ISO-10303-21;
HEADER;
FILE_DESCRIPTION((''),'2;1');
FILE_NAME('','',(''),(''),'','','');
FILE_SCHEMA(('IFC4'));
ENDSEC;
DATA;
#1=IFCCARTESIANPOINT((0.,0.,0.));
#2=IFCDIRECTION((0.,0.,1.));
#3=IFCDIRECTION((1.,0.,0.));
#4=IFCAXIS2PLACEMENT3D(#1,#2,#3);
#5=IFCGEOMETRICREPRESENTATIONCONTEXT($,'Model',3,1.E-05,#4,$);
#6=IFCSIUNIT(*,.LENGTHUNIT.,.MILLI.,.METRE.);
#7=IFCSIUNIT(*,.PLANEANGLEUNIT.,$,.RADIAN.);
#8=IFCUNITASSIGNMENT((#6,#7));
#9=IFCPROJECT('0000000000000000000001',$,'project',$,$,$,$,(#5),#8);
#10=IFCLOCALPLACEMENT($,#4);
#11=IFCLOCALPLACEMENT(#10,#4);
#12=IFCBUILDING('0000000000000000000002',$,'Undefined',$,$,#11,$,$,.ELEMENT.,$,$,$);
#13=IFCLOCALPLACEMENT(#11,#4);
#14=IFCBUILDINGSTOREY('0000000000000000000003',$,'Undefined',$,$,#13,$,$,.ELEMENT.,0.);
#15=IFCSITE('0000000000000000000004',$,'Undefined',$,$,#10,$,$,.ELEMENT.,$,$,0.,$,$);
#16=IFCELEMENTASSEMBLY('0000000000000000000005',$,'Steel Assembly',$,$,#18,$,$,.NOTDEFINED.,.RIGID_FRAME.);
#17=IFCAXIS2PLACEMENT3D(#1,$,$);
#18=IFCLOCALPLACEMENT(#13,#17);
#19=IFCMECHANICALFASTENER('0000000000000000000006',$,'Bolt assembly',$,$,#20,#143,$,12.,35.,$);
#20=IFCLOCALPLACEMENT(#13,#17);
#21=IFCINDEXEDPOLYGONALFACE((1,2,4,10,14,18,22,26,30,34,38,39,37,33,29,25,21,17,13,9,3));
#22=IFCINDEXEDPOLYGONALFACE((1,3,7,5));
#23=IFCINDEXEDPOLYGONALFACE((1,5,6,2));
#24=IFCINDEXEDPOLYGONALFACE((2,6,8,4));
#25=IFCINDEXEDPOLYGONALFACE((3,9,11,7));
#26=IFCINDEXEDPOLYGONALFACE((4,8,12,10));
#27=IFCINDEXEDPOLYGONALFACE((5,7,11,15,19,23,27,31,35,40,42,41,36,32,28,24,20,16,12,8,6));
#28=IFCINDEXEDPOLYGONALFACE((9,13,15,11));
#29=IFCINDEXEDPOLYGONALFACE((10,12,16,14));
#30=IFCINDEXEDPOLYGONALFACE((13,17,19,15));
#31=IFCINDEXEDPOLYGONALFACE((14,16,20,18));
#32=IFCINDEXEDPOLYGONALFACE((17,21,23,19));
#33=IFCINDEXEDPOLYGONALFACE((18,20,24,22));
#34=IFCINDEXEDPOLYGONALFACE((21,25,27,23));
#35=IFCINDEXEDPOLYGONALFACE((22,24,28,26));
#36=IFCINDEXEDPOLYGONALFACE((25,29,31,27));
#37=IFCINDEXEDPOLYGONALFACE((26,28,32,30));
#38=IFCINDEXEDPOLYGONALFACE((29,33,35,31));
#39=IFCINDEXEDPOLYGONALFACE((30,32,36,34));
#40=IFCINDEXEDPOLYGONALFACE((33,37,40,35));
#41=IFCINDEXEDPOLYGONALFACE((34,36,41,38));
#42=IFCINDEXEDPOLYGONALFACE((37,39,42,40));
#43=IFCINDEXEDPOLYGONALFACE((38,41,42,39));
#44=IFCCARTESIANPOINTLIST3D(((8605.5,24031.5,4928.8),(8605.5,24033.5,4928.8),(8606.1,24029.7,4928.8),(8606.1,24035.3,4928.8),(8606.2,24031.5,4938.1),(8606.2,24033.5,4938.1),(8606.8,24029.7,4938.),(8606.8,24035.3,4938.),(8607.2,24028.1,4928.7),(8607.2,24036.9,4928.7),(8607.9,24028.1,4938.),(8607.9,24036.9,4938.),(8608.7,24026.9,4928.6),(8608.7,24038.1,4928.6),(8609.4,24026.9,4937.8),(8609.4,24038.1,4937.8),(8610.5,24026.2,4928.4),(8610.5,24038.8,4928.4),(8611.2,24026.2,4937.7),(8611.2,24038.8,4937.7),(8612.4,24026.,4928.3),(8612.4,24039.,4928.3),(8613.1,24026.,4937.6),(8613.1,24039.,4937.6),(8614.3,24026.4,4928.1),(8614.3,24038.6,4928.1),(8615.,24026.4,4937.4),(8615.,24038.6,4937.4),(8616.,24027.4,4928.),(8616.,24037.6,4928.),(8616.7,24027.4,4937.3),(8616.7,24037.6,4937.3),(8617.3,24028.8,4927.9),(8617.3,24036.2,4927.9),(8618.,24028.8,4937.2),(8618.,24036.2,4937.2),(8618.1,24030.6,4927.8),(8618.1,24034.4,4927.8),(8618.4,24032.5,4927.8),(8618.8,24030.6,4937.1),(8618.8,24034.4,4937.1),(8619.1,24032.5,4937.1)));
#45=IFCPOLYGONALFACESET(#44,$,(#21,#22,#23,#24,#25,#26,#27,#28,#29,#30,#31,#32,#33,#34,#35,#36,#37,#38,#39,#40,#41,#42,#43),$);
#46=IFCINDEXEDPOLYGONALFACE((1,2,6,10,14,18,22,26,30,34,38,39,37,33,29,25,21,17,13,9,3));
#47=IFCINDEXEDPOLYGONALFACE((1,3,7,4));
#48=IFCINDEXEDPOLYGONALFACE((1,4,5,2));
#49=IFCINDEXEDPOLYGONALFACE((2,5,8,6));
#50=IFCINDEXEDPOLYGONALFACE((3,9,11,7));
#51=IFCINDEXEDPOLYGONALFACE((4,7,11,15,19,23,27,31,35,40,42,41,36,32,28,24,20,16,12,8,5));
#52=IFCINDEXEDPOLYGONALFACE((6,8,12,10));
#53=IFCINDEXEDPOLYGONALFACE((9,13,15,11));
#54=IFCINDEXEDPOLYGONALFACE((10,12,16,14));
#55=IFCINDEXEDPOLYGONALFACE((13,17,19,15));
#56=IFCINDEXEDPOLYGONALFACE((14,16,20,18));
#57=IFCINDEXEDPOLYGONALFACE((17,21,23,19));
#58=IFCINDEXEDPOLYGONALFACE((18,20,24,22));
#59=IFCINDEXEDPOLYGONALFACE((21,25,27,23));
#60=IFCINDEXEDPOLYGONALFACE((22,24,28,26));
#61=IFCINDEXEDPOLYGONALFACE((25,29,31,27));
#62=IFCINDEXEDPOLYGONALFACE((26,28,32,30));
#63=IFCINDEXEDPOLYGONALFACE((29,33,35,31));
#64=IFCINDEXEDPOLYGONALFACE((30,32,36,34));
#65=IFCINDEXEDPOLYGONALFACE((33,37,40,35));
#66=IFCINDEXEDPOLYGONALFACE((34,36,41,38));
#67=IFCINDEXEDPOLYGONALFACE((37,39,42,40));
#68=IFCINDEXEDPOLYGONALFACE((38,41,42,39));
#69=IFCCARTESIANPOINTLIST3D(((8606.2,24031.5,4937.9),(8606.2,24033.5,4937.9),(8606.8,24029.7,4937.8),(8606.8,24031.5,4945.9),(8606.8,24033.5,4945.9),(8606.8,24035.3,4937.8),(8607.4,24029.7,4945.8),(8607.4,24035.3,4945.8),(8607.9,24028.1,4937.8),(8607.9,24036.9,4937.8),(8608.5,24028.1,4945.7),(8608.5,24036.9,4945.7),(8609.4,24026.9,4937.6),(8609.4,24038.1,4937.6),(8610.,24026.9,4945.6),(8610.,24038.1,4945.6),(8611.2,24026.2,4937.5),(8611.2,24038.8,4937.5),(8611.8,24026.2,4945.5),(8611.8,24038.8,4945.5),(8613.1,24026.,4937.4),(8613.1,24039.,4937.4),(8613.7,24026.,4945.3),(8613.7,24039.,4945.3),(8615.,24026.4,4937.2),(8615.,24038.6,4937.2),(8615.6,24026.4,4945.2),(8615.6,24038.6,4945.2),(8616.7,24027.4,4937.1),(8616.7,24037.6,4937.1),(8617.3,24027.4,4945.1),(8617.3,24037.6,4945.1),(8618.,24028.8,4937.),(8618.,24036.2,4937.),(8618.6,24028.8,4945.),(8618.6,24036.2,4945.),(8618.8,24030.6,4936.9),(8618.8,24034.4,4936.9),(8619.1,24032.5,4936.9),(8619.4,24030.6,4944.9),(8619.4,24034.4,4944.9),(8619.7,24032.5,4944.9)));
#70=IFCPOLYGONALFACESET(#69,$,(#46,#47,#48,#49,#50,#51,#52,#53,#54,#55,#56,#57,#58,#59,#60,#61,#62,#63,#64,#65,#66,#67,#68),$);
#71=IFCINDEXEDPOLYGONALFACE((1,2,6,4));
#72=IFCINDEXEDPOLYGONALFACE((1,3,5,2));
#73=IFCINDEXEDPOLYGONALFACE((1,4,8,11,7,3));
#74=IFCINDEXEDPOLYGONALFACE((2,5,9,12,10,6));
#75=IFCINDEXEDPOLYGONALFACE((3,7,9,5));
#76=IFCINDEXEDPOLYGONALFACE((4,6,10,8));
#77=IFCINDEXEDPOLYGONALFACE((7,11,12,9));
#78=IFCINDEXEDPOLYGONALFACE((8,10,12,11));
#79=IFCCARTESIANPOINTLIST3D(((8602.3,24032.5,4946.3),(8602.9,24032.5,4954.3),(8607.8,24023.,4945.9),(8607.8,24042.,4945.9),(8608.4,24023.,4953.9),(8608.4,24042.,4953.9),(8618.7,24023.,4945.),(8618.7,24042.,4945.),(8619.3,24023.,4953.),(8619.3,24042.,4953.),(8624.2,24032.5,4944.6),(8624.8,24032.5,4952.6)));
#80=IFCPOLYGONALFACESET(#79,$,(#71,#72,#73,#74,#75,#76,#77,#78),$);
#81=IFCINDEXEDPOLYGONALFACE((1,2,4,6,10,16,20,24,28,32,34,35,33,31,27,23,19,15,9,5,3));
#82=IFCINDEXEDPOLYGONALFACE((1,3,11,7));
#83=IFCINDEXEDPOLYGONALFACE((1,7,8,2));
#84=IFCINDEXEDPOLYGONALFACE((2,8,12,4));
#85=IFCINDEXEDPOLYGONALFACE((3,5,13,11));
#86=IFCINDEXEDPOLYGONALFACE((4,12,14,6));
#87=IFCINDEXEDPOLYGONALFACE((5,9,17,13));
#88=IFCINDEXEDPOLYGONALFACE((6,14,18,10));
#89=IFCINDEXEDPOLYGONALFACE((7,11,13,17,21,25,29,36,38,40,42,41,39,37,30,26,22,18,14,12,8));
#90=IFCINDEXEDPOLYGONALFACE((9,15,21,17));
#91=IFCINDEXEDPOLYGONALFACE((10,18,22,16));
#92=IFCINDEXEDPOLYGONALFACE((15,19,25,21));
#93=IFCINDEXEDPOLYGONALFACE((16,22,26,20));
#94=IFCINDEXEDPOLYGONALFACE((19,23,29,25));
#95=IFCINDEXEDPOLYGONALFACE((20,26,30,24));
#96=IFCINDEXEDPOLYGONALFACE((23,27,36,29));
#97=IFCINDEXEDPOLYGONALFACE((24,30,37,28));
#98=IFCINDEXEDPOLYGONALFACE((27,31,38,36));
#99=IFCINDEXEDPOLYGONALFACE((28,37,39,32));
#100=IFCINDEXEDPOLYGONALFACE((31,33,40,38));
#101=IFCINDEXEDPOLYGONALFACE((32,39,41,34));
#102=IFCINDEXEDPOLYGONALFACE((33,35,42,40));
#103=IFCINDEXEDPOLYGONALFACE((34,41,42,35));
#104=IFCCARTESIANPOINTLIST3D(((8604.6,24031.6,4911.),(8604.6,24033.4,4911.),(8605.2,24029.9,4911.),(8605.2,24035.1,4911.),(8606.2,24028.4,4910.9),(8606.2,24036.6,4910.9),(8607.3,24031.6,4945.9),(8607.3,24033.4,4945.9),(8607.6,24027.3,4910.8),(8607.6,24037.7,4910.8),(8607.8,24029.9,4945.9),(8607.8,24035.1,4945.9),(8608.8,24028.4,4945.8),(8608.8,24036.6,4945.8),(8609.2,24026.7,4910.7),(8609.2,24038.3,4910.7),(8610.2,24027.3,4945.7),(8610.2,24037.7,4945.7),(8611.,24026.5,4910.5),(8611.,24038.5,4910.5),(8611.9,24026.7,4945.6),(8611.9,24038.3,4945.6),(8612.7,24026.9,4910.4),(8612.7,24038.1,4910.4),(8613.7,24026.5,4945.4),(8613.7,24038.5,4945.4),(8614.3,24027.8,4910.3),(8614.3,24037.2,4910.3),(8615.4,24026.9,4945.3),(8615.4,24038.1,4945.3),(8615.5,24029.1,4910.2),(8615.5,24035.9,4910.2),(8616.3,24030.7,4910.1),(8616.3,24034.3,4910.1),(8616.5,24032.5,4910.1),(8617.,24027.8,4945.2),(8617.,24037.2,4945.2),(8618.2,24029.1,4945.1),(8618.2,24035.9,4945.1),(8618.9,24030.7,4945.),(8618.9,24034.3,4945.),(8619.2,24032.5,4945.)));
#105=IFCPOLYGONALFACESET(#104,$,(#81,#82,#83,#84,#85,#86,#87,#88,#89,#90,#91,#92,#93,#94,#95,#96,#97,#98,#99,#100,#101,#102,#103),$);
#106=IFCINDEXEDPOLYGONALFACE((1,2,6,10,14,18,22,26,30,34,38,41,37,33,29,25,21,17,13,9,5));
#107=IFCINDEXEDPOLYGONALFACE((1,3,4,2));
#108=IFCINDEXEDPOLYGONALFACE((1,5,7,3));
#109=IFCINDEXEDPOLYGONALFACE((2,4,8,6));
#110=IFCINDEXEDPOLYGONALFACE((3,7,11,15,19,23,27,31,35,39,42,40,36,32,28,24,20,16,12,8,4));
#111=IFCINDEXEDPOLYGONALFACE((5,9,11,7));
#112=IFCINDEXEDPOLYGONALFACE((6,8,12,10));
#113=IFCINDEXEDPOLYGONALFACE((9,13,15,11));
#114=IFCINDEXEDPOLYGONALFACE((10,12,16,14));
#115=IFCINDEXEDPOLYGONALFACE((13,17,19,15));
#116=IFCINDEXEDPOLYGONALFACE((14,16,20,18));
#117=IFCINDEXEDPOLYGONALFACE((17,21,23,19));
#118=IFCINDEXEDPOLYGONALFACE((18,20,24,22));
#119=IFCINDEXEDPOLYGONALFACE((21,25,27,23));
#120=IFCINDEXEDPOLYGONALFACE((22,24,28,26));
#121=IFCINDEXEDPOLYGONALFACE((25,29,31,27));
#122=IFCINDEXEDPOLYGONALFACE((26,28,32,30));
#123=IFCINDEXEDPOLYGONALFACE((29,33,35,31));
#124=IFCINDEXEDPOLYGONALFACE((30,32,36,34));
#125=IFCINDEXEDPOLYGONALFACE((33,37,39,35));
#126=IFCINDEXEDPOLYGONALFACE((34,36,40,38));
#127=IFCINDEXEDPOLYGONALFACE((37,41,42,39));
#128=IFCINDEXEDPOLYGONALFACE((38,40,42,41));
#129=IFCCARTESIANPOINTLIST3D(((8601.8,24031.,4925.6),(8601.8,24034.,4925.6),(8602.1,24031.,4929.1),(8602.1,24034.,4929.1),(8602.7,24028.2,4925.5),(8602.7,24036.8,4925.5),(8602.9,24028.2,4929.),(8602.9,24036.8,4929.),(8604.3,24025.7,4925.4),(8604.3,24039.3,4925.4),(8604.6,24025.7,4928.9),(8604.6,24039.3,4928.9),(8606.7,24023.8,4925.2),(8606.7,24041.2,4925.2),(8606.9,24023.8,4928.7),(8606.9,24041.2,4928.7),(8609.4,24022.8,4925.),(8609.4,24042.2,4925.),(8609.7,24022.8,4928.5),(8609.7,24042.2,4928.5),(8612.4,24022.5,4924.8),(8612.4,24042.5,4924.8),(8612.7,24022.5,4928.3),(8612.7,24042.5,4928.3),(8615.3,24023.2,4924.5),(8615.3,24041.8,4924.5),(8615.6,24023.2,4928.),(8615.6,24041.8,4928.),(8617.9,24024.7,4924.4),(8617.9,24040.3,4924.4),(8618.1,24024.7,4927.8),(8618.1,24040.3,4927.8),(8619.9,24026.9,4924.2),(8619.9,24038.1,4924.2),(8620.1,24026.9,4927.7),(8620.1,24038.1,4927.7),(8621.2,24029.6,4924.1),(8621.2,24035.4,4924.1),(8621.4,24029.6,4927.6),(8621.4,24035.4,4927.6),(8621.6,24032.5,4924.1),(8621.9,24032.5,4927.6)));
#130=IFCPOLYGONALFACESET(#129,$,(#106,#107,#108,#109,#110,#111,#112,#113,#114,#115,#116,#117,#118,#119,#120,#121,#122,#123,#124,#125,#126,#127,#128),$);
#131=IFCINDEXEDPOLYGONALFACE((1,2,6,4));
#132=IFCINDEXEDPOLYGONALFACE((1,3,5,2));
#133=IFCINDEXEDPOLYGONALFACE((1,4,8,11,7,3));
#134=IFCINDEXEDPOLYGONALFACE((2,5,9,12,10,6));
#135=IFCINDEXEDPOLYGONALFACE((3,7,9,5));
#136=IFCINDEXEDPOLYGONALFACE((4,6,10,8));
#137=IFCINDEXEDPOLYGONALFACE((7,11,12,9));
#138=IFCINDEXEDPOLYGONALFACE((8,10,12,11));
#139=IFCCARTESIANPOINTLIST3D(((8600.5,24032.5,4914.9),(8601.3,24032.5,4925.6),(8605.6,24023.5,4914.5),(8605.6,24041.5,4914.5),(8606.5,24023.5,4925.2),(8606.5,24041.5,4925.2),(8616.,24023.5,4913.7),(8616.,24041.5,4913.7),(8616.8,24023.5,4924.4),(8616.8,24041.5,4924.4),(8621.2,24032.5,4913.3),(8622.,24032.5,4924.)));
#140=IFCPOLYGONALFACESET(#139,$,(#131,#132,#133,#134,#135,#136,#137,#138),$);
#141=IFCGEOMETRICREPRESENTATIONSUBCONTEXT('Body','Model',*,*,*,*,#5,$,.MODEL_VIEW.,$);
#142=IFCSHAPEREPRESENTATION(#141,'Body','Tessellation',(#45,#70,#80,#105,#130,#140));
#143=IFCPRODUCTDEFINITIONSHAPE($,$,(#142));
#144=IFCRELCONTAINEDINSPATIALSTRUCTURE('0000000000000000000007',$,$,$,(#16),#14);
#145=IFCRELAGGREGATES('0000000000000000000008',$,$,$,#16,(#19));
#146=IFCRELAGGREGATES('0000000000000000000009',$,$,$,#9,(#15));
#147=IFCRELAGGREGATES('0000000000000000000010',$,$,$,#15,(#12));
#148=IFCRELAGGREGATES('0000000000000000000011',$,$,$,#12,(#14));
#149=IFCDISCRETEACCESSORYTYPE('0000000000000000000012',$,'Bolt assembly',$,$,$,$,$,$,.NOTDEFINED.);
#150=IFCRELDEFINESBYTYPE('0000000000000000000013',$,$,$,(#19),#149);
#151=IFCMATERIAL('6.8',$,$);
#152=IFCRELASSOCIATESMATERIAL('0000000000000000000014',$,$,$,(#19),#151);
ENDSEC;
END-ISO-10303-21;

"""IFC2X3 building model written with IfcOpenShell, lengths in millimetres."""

from ifc_helpers import new_model, si_unit, frame, origin_with_axes, origin_2d_with_axis, place, context, subcontext, project, spatial, polyline, circle, outline, extrude, source, transform, mapped, material, type_object, element, aggregate, save


model = new_model("IFC2X3")

# Units and contexts
model_context = context("Model", 3, precision=1e-05, world=origin_with_axes())
body_context = subcontext(model_context, "Body", "Model", "MODEL_VIEW")
ifc_project = project(units=[si_unit("LENGTHUNIT", "METRE", prefix="MILLI"), si_unit("PLANEANGLEUNIT", "RADIAN")], contexts=[model_context])

# Site, building, storey
site_placement = place(None, origin_with_axes())
site = spatial("IfcSite", under=ifc_project, at=site_placement, Name="Undefined", CompositionType="ELEMENT", RefElevation=0.0)
building_placement = place(site_placement, origin_with_axes())
building = spatial("IfcBuilding", under=site, at=building_placement, Name="Undefined", CompositionType="ELEMENT")
storey_placement = place(building_placement, origin_with_axes())
storey = spatial("IfcBuildingStorey", under=building, at=storey_placement, Name="Undefined", CompositionType="ELEMENT", Elevation=0.0)

# Shared definitions
ifc_material_1 = material(Name="6.8")
discrete_accessory_type_1 = type_object("IfcDiscreteAccessoryType", Name="Bolt assembly")

# Element assembly, mechanical fastener
shared_shape_1 = source(origin_with_axes(), body_context, "Body", "SweptSolid", [
    extrude(circle(Radius=6.5, at=origin_2d_with_axis()), frame((0.0, -0.1, 0.0), z_axis=(0.0, 1.0, 0.0), x_axis=(1.0, 0.0, 0.0)), (0.0, 0.0, 1.0), 9.3),
    extrude(circle(Radius=6.5, at=origin_2d_with_axis()), frame((0.0, -7.9, 0.0), z_axis=(0.0, 1.0, 0.0), x_axis=(1.0, 0.0, 0.0)), (0.0, 0.0, 1.0), 8.0),
    extrude(outline(polyline([(11.0, 0.0), (5.5, 9.5), (-5.5, 9.5), (-11.0, 0.0), (-5.5, -9.5), (5.5, -9.5), (11.0, 0.0)])), frame((0.0, -16.0, 0.0), z_axis=(0.0, 1.0, 0.0), x_axis=(1.0, 0.0, 0.0)), (0.0, 0.0, 1.0), 8.0),
    extrude(circle(Radius=6.0, at=origin_2d_with_axis()), frame((0.0, -8.0, 0.0), z_axis=(0.0, 1.0, 0.0), x_axis=(1.0, 0.0, 0.0)), (0.0, 0.0, 1.0), 35.0),
    extrude(circle(Radius=10.0, at=origin_2d_with_axis()), frame((0.0, 9.2, 0.0), z_axis=(0.0, 1.0, 0.0), x_axis=(1.0, 0.0, 0.0)), (0.0, 0.0, 1.0), 3.5),
    extrude(outline(polyline([(10.4, 0.0), (5.2, 9.0), (-5.2, 9.0), (-10.4, 0.0), (-5.2, -9.0), (5.2, -9.0), (10.4, 0.0)])), frame((0.0, 12.7, 0.0), z_axis=(0.0, 1.0, 0.0), x_axis=(1.0, 0.0, 0.0)), (0.0, 0.0, 1.0), 10.8),
])
assembly_1_placement = place(storey_placement, origin_with_axes())
assembly_1 = element("IfcElementAssembly", 1, at=assembly_1_placement, inside=storey, Name="Steel Assembly", AssemblyPlace="NOTDEFINED", PredefinedType="RIGID_FRAME")
mechanical_fastener_1_placement = place(assembly_1_placement, frame((8612.6, 24032.5, 4937.5), z_axis=(0.0, 1.0, 0.0), x_axis=(0.997054, 0.0, -0.076696)))
mechanical_fastener_1 = element("IfcMechanicalFastener", 2, at=mechanical_fastener_1_placement, type_object=discrete_accessory_type_1, material=ifc_material_1, Name="Bolt assembly", NominalDiameter=12.0, NominalLength=35.0, context=body_context, shape_type="MappedRepresentation", body=[
    mapped(shared_shape_1, transform((0.0, 0.0, 0.0))),
])
aggregate(assembly_1, [mechanical_fastener_1])

save(model, "model.ifc")
